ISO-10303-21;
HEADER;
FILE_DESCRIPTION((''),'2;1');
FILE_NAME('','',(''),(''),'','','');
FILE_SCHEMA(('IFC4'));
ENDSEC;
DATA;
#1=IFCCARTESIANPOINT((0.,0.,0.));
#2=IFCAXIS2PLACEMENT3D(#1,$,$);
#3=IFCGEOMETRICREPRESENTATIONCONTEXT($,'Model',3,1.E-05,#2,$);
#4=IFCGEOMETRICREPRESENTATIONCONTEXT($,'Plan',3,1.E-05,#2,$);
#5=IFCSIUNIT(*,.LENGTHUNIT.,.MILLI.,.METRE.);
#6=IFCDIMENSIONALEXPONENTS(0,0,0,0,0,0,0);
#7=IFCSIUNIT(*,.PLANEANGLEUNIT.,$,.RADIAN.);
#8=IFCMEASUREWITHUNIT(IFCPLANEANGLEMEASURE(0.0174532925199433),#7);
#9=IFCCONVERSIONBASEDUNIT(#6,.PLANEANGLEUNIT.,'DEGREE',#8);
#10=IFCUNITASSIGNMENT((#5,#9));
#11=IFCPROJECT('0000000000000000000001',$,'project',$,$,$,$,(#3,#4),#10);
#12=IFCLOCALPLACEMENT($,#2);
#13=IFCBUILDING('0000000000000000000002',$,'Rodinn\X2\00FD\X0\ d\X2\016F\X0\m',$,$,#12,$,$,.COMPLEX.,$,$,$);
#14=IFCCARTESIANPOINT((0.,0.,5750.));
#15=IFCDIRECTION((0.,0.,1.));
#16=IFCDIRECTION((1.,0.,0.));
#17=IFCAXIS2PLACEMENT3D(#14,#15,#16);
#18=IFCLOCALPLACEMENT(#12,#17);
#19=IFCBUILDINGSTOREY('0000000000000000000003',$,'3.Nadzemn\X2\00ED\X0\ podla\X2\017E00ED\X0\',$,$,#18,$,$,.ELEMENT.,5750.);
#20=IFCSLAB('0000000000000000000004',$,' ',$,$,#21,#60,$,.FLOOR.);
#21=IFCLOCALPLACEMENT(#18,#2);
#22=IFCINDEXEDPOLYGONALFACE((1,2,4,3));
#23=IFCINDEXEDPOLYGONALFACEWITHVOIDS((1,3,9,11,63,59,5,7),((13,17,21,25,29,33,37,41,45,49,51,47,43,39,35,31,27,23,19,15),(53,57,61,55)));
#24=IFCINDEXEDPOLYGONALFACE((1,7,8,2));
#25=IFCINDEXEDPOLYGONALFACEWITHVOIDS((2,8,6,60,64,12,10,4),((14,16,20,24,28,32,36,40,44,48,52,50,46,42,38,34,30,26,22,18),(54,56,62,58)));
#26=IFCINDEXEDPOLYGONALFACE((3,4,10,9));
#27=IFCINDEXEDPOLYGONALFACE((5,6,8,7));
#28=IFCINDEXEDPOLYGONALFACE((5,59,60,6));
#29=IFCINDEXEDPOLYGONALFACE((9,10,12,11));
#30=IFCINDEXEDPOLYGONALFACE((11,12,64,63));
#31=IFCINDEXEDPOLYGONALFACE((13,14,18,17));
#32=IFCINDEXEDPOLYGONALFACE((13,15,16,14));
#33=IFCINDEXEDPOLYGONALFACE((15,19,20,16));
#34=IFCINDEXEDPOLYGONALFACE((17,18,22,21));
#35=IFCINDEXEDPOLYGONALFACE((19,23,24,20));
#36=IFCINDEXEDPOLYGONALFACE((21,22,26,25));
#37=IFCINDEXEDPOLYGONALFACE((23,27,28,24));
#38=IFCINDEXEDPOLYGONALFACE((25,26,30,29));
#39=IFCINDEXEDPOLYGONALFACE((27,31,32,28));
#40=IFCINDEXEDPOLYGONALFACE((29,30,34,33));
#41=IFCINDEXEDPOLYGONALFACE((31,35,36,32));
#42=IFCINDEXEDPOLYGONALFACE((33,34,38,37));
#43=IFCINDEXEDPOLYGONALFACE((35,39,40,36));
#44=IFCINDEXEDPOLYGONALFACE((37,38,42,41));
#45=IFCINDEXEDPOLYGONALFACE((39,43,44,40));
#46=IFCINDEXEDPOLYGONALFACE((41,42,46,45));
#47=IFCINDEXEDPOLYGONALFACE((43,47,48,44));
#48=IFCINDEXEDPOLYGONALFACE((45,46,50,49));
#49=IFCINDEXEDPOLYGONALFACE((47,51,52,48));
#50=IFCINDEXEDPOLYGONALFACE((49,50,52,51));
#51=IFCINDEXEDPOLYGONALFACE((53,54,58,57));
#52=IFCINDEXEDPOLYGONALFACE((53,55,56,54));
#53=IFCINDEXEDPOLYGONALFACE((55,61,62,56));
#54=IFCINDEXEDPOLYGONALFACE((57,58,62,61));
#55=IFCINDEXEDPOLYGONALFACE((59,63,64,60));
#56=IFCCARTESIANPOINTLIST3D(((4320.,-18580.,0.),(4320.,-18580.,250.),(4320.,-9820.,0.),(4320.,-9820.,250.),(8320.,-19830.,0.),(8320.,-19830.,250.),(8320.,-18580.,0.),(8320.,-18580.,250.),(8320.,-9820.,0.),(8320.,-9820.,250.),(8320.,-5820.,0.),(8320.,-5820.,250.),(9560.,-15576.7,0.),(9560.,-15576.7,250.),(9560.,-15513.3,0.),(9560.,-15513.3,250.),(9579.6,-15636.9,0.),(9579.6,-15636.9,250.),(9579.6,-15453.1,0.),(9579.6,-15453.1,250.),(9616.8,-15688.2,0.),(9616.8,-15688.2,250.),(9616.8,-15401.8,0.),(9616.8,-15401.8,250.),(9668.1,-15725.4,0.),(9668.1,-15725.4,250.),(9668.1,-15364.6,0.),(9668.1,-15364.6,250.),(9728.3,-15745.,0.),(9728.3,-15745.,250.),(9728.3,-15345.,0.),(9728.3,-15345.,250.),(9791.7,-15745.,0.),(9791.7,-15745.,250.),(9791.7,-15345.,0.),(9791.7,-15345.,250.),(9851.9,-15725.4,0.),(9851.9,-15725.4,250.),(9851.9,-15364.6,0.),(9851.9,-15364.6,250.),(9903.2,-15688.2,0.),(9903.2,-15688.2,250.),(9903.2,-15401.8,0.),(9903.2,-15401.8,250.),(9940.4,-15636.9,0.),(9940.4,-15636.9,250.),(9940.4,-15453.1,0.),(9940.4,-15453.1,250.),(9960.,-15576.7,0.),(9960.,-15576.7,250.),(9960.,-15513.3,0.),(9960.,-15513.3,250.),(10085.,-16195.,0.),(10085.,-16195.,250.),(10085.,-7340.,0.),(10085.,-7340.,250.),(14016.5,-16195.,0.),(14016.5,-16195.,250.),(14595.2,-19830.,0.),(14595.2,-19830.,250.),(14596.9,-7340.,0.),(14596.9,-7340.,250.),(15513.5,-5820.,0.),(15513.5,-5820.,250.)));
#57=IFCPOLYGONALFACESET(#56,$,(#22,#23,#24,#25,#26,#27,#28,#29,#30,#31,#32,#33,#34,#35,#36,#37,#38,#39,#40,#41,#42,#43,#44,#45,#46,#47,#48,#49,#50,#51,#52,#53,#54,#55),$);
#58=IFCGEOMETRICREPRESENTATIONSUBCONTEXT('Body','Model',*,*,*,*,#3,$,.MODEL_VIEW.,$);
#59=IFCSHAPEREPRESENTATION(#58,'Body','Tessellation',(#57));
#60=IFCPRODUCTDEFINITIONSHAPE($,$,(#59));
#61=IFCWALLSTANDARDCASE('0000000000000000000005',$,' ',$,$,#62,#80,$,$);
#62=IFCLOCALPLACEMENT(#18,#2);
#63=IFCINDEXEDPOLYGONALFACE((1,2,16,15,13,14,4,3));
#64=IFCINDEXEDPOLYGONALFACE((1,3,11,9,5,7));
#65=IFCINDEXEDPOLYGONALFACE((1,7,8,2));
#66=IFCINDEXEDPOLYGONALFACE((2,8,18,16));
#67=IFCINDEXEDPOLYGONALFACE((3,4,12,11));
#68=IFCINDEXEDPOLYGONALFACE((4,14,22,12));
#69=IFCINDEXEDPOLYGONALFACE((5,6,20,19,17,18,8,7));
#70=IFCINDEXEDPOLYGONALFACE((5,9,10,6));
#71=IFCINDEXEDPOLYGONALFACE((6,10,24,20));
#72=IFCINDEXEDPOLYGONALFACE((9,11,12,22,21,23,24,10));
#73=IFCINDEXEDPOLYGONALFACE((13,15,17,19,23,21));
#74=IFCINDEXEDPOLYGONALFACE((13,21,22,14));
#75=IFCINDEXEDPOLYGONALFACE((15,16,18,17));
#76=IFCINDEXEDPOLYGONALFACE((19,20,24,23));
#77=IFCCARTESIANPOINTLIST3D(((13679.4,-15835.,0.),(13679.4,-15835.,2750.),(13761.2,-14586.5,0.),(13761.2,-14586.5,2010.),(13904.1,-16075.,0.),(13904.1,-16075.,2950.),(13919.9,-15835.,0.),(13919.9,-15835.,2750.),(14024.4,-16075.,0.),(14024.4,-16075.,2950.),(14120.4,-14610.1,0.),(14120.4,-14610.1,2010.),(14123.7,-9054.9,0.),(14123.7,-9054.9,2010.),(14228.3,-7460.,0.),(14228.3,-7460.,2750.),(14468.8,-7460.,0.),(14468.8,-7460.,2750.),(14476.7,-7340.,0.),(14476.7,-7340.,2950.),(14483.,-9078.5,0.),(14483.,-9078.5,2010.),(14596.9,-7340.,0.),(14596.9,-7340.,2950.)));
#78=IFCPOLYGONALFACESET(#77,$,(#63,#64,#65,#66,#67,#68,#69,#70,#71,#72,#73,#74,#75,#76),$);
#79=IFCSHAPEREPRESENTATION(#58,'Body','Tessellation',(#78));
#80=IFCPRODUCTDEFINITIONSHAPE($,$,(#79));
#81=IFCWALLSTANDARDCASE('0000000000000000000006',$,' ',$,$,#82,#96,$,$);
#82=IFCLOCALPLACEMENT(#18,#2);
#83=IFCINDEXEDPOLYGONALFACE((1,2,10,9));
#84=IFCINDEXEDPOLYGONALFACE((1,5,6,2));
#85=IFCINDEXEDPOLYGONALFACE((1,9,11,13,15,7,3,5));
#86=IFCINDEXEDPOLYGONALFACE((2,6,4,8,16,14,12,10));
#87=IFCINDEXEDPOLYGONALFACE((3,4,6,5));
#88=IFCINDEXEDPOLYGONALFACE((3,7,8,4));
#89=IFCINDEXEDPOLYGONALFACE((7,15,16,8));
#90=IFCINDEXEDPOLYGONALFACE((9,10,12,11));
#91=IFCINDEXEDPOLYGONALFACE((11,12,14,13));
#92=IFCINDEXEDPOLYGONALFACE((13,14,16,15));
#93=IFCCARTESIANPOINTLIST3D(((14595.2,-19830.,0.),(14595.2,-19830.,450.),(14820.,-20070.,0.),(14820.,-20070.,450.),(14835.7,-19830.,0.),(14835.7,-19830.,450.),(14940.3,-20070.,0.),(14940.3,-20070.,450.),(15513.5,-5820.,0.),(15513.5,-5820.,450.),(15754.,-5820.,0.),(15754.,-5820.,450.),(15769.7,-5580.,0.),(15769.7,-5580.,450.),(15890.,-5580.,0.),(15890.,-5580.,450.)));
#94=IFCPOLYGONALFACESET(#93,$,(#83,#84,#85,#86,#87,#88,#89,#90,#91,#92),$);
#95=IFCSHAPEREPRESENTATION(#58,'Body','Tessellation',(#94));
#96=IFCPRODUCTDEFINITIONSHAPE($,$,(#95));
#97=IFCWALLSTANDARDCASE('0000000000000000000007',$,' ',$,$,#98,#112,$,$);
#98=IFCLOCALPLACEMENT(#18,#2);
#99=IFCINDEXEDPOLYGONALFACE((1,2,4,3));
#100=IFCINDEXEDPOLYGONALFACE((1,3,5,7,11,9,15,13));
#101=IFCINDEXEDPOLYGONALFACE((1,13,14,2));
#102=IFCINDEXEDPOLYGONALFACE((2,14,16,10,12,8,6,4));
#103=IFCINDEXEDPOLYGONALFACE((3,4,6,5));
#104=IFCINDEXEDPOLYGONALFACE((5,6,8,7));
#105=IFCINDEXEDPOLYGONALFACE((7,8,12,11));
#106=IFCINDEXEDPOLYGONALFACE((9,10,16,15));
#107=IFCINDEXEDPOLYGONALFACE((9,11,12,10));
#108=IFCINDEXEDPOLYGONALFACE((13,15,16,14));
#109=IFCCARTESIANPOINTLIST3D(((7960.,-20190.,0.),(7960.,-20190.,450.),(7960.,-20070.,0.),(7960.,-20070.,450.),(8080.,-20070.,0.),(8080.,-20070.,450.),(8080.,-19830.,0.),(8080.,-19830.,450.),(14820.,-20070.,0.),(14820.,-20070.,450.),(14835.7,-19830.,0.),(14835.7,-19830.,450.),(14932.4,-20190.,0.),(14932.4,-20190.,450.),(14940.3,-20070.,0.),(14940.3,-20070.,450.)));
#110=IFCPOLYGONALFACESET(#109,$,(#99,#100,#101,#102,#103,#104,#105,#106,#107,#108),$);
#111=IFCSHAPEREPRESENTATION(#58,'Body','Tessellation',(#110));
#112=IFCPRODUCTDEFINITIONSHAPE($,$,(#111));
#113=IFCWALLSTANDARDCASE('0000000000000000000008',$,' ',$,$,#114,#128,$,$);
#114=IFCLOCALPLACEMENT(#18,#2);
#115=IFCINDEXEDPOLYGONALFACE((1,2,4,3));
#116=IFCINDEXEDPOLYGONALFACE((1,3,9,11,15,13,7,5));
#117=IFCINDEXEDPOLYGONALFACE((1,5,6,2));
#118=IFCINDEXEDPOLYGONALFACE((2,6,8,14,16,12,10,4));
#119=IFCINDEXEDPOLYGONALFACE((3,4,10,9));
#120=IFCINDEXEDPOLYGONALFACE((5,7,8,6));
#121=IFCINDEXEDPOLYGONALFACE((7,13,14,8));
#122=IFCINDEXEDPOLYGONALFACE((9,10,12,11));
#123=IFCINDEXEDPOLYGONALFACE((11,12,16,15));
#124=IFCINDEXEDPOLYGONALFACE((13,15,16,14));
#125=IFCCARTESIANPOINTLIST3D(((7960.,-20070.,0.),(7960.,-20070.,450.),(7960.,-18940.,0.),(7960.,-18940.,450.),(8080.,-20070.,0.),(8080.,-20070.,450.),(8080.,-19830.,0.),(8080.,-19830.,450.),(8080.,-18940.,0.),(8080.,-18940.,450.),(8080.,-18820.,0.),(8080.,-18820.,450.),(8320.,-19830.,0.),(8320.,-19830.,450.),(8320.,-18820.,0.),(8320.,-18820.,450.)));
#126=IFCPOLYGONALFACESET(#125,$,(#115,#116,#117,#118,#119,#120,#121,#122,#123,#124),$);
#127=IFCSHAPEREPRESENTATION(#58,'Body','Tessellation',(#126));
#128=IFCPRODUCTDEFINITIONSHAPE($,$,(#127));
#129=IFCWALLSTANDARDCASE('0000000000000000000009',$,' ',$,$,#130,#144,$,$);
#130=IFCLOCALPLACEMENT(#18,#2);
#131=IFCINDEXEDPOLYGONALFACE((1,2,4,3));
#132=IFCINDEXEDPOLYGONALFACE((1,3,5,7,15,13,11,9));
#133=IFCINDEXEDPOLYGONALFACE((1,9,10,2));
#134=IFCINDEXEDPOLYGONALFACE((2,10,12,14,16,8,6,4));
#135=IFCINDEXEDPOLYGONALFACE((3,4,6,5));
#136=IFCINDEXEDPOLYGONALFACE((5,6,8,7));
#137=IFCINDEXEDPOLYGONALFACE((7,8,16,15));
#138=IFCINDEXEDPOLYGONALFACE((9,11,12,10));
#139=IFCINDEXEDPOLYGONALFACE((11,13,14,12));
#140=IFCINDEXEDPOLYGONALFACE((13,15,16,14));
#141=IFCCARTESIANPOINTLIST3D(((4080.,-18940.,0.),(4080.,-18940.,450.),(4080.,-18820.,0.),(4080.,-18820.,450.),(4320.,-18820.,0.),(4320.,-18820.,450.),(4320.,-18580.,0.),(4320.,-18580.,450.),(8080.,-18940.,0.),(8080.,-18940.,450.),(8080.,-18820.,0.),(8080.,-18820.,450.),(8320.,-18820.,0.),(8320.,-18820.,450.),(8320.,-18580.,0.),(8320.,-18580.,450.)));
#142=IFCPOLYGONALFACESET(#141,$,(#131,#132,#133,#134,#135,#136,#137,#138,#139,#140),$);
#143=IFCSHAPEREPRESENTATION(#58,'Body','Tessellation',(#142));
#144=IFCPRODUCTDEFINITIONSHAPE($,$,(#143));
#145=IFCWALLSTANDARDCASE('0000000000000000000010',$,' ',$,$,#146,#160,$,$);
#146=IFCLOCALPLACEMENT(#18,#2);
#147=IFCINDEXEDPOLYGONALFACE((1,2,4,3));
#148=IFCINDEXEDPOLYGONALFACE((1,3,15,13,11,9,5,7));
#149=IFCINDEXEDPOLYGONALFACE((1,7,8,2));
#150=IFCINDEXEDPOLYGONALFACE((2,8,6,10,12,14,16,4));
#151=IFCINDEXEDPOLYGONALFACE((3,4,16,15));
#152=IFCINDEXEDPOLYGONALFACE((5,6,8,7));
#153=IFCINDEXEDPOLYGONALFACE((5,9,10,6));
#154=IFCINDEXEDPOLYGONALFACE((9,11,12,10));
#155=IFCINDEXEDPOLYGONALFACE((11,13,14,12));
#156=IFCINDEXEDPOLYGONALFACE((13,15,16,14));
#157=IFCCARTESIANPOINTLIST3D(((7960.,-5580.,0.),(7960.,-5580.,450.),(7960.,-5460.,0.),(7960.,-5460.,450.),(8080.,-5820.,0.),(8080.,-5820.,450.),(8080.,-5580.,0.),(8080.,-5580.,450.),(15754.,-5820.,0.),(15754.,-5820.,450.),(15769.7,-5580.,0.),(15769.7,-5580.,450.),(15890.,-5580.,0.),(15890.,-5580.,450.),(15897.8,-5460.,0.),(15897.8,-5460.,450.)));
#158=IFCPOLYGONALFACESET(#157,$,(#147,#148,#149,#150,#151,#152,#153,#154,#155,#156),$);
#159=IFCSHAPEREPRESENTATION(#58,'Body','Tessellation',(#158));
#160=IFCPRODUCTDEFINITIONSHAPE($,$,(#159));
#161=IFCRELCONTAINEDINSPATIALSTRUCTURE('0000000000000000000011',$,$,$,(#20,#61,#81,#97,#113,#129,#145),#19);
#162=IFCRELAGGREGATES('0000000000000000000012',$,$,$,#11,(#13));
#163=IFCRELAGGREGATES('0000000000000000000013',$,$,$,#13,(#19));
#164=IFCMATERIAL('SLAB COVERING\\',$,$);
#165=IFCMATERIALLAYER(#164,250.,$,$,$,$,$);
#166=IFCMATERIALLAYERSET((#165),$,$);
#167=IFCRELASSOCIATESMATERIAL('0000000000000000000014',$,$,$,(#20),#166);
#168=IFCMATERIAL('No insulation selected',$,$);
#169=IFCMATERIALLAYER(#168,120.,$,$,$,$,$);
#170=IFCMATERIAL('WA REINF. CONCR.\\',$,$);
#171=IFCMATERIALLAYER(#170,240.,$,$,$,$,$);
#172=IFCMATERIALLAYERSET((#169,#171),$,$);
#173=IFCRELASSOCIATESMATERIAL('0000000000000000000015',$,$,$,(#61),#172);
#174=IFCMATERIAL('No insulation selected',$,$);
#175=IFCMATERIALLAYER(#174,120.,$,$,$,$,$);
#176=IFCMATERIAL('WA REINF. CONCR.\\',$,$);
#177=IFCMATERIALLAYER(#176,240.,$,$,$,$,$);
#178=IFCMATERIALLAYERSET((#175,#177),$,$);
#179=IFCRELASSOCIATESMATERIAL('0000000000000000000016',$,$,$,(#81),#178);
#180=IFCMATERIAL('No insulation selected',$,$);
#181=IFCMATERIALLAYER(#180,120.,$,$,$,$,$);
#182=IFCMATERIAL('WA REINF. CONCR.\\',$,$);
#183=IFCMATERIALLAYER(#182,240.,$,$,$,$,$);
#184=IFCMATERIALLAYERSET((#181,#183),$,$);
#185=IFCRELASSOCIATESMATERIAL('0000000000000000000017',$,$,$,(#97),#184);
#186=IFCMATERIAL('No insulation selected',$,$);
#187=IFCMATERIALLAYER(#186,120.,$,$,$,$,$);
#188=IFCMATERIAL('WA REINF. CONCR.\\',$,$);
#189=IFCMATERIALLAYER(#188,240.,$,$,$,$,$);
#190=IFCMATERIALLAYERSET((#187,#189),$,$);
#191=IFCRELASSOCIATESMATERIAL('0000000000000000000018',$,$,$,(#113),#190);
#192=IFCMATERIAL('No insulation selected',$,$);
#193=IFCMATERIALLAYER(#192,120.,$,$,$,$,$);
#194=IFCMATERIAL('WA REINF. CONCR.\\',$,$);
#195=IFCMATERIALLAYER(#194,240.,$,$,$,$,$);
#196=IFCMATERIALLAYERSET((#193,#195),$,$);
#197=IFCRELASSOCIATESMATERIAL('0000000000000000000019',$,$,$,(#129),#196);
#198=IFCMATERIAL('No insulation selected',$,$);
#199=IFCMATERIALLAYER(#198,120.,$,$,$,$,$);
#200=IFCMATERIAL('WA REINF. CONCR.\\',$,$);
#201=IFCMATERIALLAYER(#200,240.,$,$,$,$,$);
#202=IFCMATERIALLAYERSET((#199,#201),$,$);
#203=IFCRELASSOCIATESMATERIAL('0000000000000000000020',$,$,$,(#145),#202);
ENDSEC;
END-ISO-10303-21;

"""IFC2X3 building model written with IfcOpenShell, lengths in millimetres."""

from ifc_helpers import new_model, entity, si_unit, converted_unit, frame, frame_2d, origin, origin_with_axes, place, context, subcontext, project, spatial, polyline, rectangle, outline, extrude, clip, bounded_halfspace, material, layer, layer_set, layer_usage, element, save


model = new_model("IFC2X3")

# Units and contexts
model_context = context("Model", 3, precision=1e-05, world=origin())
plan_context = context("Plan", 3, precision=1e-05, world=origin())
body_context = subcontext(model_context, "Body", "Model", "MODEL_VIEW")
ifc_project = project(units=[si_unit("LENGTHUNIT", "METRE", prefix="MILLI"), converted_unit("PLANEANGLEUNIT", "DEGREE", entity("IfcPlaneAngleMeasure", 0.0174532925199433), si_unit("PLANEANGLEUNIT", "RADIAN"), dimensions=[0, 0, 0, 0, 0, 0, 0])], contexts=[model_context, plan_context])

# Building, storey
building_placement = place(None, origin())
building = spatial("IfcBuilding", under=ifc_project, at=building_placement, Name="Rodinný dům", CompositionType="COMPLEX")
storey_placement = place(building_placement, frame((0.0, 0.0, 5750.0), z_axis=(0.0, 0.0, 1.0), x_axis=(1.0, 0.0, 0.0)))
storey = spatial("IfcBuildingStorey", under=building, at=storey_placement, Name="3.Nadzemní podlaží", CompositionType="ELEMENT", Elevation=5750.0)

# Slab
ifc_material_1 = material(Name="SLAB COVERING\\")
ifc_layer_1 = layer(ifc_material_1, 250.0)
ifc_layer_set_1 = layer_set([ifc_layer_1])
ifc_layer_usage_1 = layer_usage(ifc_layer_set_1, "AXIS3", "POSITIVE", 0.0)
slab_placement = place(storey_placement, frame((4320.0, -19830.0, 0.0), z_axis=(0.0, 0.0, 1.0), x_axis=(1.0, 0.0, 0.0)))
element("IfcSlab", 1, at=slab_placement, inside=storey, material=ifc_layer_usage_1, Name=" ", PredefinedType="FLOOR", context=body_context, shape_type="SweptSolid", body=[
    extrude(outline(polyline([(4000.0, 0.0), (10275.2, 0.0), (11193.5, 14010.0), (4000.0, 14010.0), (4000.0, 10010.0), (0.0, 10010.0), (0.0, 1250.0), (4000.0, 1250.0), (4000.0, 0.0)]), holes=[polyline([(5471.7, 4485.0), (5531.9, 4465.4), (5583.2, 4428.2), (5620.4, 4376.9), (5640.0, 4316.7), (5640.0, 4253.3), (5620.4, 4193.1), (5583.2, 4141.8), (5531.9, 4104.6), (5471.7, 4085.0), (5408.3, 4085.0), (5348.1, 4104.6), (5296.8, 4141.8), (5259.6, 4193.1), (5240.0, 4253.3), (5240.0, 4316.7), (5259.6, 4376.9), (5296.8, 4428.2), (5348.1, 4465.4), (5408.3, 4485.0), (5471.7, 4485.0)]), polyline([(10276.9, 12490.0), (9696.5, 3635.0), (5765.0, 3635.0), (5765.0, 12490.0), (10276.9, 12490.0)])]), origin_with_axes(), (0.0, 0.0, 1.0), 250.0),
])

# Wall, opening
ifc_material_2 = material(Name="No insulation selected")
ifc_layer_2 = layer(ifc_material_2, 120.0)
ifc_material_3 = material(Name="WA REINF. CONCR.\\")
ifc_layer_3 = layer(ifc_material_3, 240.0)
ifc_layer_set_2 = layer_set([ifc_layer_2, ifc_layer_3])
ifc_layer_usage_2 = layer_usage(ifc_layer_set_2, "AXIS2", "POSITIVE", -120.0)
wall_1_placement = place(storey_placement, frame((14024.4, -16075.0, 0.0), z_axis=(0.0, 0.0, 1.0), x_axis=(0.065403, 0.997859, 0.0)))
wall_1 = element("IfcWallStandardCase", 2, at=wall_1_placement, inside=storey, material=ifc_layer_usage_2, Name=" ", context=body_context, shape_type="Clipping", body=[
    clip(clip(extrude(outline(polyline([(0.0, 0.0), (8753.7, 0.0), (8745.9, 120.0), (8625.6, 120.0), (8609.9, 360.0), (216.9, 360.0), (232.6, 120.0), (-7.9, 120.0), (0.0, 0.0)])), origin_with_axes(), (0.0, 0.0, 1.0), 2950.0), bounded_halfspace(frame((0.0, 0.0, 2950.0), z_axis=(0.0, 0.0, -1.0), x_axis=(1.0, 0.0, 0.0)), True, origin(), polyline([(0.0, 0.0), (8753.7, 0.0), (8745.9, 120.0), (-7.9, 120.0), (0.0, 0.0)]))), bounded_halfspace(frame((232.6, 120.0, 2750.0), z_axis=(0.0, 0.0, -1.0), x_axis=(1.0, 0.0, 0.0)), True, origin(), polyline([(232.6, 120.0), (8625.6, 120.0), (8609.9, 360.0), (216.9, 360.0), (232.6, 120.0)]))),
])
opening_1_placement = place(wall_1_placement, frame((1468.1, 0.0, 0.0), z_axis=(0.0, 1.0, 0.0), x_axis=(0.0, 0.0, 1.0)))
element("IfcOpeningElement", 3, at=opening_1_placement, cuts=wall_1, ObjectType="Opening", context=body_context, shape_type="SweptSolid", body=[
    extrude(rectangle(XDim=2010.0, YDim=5543.5, at=frame_2d((1005.0, 2771.7), x_axis=(1.0, 0.0))), origin_with_axes(), (0.0, 0.0, 1.0), 360.0),
])

# Walls
ifc_material_4 = material(Name="No insulation selected")
ifc_layer_4 = layer(ifc_material_4, 120.0)
ifc_material_5 = material(Name="WA REINF. CONCR.\\")
ifc_layer_5 = layer(ifc_material_5, 240.0)
ifc_layer_set_3 = layer_set([ifc_layer_4, ifc_layer_5])
ifc_layer_usage_3 = layer_usage(ifc_layer_set_3, "AXIS2", "POSITIVE", -120.0)
wall_2_placement = place(storey_placement, frame((14940.3, -20070.0, 0.0), z_axis=(0.0, 0.0, 1.0), x_axis=(0.065403, 0.997859, 0.0)))
element("IfcWallStandardCase", 4, at=wall_2_placement, inside=storey, material=ifc_layer_usage_3, Name=" ", context=body_context, shape_type="SweptSolid", body=[
    extrude(outline(polyline([(0.0, 0.0), (14521.1, 0.0), (14513.2, 120.0), (14272.7, 120.0), (14257.0, 360.0), (216.9, 360.0), (232.6, 120.0), (-7.9, 120.0), (0.0, 0.0)])), origin_with_axes(), (0.0, 0.0, 1.0), 450.0),
])
ifc_material_6 = material(Name="No insulation selected")
ifc_layer_6 = layer(ifc_material_6, 120.0)
ifc_material_7 = material(Name="WA REINF. CONCR.\\")
ifc_layer_7 = layer(ifc_material_7, 240.0)
ifc_layer_set_4 = layer_set([ifc_layer_6, ifc_layer_7])
ifc_layer_usage_4 = layer_usage(ifc_layer_set_4, "AXIS2", "POSITIVE", -120.0)
wall_3_placement = place(storey_placement, frame((7960.0, -20190.0, 0.0), z_axis=(0.0, 0.0, 1.0), x_axis=(1.0, 0.0, 0.0)))
element("IfcWallStandardCase", 5, at=wall_3_placement, inside=storey, material=ifc_layer_usage_4, Name=" ", context=body_context, shape_type="SweptSolid", body=[
    extrude(outline(polyline([(0.0, 0.0), (6972.4, 0.0), (6980.3, 120.0), (6860.0, 120.0), (6875.7, 360.0), (120.0, 360.0), (120.0, 120.0), (0.0, 120.0), (0.0, 0.0)])), origin_with_axes(), (0.0, 0.0, 1.0), 450.0),
])
ifc_material_8 = material(Name="No insulation selected")
ifc_layer_8 = layer(ifc_material_8, 120.0)
ifc_material_9 = material(Name="WA REINF. CONCR.\\")
ifc_layer_9 = layer(ifc_material_9, 240.0)
ifc_layer_set_5 = layer_set([ifc_layer_8, ifc_layer_9])
ifc_layer_usage_5 = layer_usage(ifc_layer_set_5, "AXIS2", "POSITIVE", -120.0)
wall_4_placement = place(storey_placement, frame((7960.0, -18940.0, 0.0), z_axis=(0.0, 0.0, 1.0), x_axis=(0.0, -1.0, 0.0)))
element("IfcWallStandardCase", 6, at=wall_4_placement, inside=storey, material=ifc_layer_usage_5, Name=" ", context=body_context, shape_type="SweptSolid", body=[
    extrude(outline(polyline([(0.0, 0.0), (1130.0, 0.0), (1130.0, 120.0), (890.0, 120.0), (890.0, 360.0), (-120.0, 360.0), (-120.0, 120.0), (0.0, 120.0), (0.0, 0.0)])), origin_with_axes(), (0.0, 0.0, 1.0), 450.0),
])
ifc_material_10 = material(Name="No insulation selected")
ifc_layer_10 = layer(ifc_material_10, 120.0)
ifc_material_11 = material(Name="WA REINF. CONCR.\\")
ifc_layer_11 = layer(ifc_material_11, 240.0)
ifc_layer_set_6 = layer_set([ifc_layer_10, ifc_layer_11])
ifc_layer_usage_6 = layer_usage(ifc_layer_set_6, "AXIS2", "POSITIVE", -120.0)
wall_5_placement = place(storey_placement, frame((4080.0, -18940.0, 0.0), z_axis=(0.0, 0.0, 1.0), x_axis=(1.0, 0.0, 0.0)))
element("IfcWallStandardCase", 7, at=wall_5_placement, inside=storey, material=ifc_layer_usage_6, Name=" ", context=body_context, shape_type="SweptSolid", body=[
    extrude(outline(polyline([(0.0, 0.0), (4000.0, 0.0), (4000.0, 120.0), (4240.0, 120.0), (4240.0, 360.0), (240.0, 360.0), (240.0, 120.0), (0.0, 120.0), (0.0, 0.0)])), origin_with_axes(), (0.0, 0.0, 1.0), 450.0),
])
ifc_material_12 = material(Name="No insulation selected")
ifc_layer_12 = layer(ifc_material_12, 120.0)
ifc_material_13 = material(Name="WA REINF. CONCR.\\")
ifc_layer_13 = layer(ifc_material_13, 240.0)
ifc_layer_set_7 = layer_set([ifc_layer_12, ifc_layer_13])
ifc_layer_usage_7 = layer_usage(ifc_layer_set_7, "AXIS2", "POSITIVE", -120.0)
wall_6_placement = place(storey_placement, frame((15897.8, -5460.0, 0.0), z_axis=(0.0, 0.0, 1.0), x_axis=(-1.0, 0.0, 0.0)))
element("IfcWallStandardCase", 8, at=wall_6_placement, inside=storey, material=ifc_layer_usage_7, Name=" ", context=body_context, shape_type="SweptSolid", body=[
    extrude(outline(polyline([(0.0, 0.0), (7937.8, 0.0), (7937.8, 120.0), (7817.8, 120.0), (7817.8, 360.0), (143.9, 360.0), (128.1, 120.0), (7.9, 120.0), (0.0, 0.0)])), origin_with_axes(), (0.0, 0.0, 1.0), 450.0),
])

save(model, "model.ifc")
